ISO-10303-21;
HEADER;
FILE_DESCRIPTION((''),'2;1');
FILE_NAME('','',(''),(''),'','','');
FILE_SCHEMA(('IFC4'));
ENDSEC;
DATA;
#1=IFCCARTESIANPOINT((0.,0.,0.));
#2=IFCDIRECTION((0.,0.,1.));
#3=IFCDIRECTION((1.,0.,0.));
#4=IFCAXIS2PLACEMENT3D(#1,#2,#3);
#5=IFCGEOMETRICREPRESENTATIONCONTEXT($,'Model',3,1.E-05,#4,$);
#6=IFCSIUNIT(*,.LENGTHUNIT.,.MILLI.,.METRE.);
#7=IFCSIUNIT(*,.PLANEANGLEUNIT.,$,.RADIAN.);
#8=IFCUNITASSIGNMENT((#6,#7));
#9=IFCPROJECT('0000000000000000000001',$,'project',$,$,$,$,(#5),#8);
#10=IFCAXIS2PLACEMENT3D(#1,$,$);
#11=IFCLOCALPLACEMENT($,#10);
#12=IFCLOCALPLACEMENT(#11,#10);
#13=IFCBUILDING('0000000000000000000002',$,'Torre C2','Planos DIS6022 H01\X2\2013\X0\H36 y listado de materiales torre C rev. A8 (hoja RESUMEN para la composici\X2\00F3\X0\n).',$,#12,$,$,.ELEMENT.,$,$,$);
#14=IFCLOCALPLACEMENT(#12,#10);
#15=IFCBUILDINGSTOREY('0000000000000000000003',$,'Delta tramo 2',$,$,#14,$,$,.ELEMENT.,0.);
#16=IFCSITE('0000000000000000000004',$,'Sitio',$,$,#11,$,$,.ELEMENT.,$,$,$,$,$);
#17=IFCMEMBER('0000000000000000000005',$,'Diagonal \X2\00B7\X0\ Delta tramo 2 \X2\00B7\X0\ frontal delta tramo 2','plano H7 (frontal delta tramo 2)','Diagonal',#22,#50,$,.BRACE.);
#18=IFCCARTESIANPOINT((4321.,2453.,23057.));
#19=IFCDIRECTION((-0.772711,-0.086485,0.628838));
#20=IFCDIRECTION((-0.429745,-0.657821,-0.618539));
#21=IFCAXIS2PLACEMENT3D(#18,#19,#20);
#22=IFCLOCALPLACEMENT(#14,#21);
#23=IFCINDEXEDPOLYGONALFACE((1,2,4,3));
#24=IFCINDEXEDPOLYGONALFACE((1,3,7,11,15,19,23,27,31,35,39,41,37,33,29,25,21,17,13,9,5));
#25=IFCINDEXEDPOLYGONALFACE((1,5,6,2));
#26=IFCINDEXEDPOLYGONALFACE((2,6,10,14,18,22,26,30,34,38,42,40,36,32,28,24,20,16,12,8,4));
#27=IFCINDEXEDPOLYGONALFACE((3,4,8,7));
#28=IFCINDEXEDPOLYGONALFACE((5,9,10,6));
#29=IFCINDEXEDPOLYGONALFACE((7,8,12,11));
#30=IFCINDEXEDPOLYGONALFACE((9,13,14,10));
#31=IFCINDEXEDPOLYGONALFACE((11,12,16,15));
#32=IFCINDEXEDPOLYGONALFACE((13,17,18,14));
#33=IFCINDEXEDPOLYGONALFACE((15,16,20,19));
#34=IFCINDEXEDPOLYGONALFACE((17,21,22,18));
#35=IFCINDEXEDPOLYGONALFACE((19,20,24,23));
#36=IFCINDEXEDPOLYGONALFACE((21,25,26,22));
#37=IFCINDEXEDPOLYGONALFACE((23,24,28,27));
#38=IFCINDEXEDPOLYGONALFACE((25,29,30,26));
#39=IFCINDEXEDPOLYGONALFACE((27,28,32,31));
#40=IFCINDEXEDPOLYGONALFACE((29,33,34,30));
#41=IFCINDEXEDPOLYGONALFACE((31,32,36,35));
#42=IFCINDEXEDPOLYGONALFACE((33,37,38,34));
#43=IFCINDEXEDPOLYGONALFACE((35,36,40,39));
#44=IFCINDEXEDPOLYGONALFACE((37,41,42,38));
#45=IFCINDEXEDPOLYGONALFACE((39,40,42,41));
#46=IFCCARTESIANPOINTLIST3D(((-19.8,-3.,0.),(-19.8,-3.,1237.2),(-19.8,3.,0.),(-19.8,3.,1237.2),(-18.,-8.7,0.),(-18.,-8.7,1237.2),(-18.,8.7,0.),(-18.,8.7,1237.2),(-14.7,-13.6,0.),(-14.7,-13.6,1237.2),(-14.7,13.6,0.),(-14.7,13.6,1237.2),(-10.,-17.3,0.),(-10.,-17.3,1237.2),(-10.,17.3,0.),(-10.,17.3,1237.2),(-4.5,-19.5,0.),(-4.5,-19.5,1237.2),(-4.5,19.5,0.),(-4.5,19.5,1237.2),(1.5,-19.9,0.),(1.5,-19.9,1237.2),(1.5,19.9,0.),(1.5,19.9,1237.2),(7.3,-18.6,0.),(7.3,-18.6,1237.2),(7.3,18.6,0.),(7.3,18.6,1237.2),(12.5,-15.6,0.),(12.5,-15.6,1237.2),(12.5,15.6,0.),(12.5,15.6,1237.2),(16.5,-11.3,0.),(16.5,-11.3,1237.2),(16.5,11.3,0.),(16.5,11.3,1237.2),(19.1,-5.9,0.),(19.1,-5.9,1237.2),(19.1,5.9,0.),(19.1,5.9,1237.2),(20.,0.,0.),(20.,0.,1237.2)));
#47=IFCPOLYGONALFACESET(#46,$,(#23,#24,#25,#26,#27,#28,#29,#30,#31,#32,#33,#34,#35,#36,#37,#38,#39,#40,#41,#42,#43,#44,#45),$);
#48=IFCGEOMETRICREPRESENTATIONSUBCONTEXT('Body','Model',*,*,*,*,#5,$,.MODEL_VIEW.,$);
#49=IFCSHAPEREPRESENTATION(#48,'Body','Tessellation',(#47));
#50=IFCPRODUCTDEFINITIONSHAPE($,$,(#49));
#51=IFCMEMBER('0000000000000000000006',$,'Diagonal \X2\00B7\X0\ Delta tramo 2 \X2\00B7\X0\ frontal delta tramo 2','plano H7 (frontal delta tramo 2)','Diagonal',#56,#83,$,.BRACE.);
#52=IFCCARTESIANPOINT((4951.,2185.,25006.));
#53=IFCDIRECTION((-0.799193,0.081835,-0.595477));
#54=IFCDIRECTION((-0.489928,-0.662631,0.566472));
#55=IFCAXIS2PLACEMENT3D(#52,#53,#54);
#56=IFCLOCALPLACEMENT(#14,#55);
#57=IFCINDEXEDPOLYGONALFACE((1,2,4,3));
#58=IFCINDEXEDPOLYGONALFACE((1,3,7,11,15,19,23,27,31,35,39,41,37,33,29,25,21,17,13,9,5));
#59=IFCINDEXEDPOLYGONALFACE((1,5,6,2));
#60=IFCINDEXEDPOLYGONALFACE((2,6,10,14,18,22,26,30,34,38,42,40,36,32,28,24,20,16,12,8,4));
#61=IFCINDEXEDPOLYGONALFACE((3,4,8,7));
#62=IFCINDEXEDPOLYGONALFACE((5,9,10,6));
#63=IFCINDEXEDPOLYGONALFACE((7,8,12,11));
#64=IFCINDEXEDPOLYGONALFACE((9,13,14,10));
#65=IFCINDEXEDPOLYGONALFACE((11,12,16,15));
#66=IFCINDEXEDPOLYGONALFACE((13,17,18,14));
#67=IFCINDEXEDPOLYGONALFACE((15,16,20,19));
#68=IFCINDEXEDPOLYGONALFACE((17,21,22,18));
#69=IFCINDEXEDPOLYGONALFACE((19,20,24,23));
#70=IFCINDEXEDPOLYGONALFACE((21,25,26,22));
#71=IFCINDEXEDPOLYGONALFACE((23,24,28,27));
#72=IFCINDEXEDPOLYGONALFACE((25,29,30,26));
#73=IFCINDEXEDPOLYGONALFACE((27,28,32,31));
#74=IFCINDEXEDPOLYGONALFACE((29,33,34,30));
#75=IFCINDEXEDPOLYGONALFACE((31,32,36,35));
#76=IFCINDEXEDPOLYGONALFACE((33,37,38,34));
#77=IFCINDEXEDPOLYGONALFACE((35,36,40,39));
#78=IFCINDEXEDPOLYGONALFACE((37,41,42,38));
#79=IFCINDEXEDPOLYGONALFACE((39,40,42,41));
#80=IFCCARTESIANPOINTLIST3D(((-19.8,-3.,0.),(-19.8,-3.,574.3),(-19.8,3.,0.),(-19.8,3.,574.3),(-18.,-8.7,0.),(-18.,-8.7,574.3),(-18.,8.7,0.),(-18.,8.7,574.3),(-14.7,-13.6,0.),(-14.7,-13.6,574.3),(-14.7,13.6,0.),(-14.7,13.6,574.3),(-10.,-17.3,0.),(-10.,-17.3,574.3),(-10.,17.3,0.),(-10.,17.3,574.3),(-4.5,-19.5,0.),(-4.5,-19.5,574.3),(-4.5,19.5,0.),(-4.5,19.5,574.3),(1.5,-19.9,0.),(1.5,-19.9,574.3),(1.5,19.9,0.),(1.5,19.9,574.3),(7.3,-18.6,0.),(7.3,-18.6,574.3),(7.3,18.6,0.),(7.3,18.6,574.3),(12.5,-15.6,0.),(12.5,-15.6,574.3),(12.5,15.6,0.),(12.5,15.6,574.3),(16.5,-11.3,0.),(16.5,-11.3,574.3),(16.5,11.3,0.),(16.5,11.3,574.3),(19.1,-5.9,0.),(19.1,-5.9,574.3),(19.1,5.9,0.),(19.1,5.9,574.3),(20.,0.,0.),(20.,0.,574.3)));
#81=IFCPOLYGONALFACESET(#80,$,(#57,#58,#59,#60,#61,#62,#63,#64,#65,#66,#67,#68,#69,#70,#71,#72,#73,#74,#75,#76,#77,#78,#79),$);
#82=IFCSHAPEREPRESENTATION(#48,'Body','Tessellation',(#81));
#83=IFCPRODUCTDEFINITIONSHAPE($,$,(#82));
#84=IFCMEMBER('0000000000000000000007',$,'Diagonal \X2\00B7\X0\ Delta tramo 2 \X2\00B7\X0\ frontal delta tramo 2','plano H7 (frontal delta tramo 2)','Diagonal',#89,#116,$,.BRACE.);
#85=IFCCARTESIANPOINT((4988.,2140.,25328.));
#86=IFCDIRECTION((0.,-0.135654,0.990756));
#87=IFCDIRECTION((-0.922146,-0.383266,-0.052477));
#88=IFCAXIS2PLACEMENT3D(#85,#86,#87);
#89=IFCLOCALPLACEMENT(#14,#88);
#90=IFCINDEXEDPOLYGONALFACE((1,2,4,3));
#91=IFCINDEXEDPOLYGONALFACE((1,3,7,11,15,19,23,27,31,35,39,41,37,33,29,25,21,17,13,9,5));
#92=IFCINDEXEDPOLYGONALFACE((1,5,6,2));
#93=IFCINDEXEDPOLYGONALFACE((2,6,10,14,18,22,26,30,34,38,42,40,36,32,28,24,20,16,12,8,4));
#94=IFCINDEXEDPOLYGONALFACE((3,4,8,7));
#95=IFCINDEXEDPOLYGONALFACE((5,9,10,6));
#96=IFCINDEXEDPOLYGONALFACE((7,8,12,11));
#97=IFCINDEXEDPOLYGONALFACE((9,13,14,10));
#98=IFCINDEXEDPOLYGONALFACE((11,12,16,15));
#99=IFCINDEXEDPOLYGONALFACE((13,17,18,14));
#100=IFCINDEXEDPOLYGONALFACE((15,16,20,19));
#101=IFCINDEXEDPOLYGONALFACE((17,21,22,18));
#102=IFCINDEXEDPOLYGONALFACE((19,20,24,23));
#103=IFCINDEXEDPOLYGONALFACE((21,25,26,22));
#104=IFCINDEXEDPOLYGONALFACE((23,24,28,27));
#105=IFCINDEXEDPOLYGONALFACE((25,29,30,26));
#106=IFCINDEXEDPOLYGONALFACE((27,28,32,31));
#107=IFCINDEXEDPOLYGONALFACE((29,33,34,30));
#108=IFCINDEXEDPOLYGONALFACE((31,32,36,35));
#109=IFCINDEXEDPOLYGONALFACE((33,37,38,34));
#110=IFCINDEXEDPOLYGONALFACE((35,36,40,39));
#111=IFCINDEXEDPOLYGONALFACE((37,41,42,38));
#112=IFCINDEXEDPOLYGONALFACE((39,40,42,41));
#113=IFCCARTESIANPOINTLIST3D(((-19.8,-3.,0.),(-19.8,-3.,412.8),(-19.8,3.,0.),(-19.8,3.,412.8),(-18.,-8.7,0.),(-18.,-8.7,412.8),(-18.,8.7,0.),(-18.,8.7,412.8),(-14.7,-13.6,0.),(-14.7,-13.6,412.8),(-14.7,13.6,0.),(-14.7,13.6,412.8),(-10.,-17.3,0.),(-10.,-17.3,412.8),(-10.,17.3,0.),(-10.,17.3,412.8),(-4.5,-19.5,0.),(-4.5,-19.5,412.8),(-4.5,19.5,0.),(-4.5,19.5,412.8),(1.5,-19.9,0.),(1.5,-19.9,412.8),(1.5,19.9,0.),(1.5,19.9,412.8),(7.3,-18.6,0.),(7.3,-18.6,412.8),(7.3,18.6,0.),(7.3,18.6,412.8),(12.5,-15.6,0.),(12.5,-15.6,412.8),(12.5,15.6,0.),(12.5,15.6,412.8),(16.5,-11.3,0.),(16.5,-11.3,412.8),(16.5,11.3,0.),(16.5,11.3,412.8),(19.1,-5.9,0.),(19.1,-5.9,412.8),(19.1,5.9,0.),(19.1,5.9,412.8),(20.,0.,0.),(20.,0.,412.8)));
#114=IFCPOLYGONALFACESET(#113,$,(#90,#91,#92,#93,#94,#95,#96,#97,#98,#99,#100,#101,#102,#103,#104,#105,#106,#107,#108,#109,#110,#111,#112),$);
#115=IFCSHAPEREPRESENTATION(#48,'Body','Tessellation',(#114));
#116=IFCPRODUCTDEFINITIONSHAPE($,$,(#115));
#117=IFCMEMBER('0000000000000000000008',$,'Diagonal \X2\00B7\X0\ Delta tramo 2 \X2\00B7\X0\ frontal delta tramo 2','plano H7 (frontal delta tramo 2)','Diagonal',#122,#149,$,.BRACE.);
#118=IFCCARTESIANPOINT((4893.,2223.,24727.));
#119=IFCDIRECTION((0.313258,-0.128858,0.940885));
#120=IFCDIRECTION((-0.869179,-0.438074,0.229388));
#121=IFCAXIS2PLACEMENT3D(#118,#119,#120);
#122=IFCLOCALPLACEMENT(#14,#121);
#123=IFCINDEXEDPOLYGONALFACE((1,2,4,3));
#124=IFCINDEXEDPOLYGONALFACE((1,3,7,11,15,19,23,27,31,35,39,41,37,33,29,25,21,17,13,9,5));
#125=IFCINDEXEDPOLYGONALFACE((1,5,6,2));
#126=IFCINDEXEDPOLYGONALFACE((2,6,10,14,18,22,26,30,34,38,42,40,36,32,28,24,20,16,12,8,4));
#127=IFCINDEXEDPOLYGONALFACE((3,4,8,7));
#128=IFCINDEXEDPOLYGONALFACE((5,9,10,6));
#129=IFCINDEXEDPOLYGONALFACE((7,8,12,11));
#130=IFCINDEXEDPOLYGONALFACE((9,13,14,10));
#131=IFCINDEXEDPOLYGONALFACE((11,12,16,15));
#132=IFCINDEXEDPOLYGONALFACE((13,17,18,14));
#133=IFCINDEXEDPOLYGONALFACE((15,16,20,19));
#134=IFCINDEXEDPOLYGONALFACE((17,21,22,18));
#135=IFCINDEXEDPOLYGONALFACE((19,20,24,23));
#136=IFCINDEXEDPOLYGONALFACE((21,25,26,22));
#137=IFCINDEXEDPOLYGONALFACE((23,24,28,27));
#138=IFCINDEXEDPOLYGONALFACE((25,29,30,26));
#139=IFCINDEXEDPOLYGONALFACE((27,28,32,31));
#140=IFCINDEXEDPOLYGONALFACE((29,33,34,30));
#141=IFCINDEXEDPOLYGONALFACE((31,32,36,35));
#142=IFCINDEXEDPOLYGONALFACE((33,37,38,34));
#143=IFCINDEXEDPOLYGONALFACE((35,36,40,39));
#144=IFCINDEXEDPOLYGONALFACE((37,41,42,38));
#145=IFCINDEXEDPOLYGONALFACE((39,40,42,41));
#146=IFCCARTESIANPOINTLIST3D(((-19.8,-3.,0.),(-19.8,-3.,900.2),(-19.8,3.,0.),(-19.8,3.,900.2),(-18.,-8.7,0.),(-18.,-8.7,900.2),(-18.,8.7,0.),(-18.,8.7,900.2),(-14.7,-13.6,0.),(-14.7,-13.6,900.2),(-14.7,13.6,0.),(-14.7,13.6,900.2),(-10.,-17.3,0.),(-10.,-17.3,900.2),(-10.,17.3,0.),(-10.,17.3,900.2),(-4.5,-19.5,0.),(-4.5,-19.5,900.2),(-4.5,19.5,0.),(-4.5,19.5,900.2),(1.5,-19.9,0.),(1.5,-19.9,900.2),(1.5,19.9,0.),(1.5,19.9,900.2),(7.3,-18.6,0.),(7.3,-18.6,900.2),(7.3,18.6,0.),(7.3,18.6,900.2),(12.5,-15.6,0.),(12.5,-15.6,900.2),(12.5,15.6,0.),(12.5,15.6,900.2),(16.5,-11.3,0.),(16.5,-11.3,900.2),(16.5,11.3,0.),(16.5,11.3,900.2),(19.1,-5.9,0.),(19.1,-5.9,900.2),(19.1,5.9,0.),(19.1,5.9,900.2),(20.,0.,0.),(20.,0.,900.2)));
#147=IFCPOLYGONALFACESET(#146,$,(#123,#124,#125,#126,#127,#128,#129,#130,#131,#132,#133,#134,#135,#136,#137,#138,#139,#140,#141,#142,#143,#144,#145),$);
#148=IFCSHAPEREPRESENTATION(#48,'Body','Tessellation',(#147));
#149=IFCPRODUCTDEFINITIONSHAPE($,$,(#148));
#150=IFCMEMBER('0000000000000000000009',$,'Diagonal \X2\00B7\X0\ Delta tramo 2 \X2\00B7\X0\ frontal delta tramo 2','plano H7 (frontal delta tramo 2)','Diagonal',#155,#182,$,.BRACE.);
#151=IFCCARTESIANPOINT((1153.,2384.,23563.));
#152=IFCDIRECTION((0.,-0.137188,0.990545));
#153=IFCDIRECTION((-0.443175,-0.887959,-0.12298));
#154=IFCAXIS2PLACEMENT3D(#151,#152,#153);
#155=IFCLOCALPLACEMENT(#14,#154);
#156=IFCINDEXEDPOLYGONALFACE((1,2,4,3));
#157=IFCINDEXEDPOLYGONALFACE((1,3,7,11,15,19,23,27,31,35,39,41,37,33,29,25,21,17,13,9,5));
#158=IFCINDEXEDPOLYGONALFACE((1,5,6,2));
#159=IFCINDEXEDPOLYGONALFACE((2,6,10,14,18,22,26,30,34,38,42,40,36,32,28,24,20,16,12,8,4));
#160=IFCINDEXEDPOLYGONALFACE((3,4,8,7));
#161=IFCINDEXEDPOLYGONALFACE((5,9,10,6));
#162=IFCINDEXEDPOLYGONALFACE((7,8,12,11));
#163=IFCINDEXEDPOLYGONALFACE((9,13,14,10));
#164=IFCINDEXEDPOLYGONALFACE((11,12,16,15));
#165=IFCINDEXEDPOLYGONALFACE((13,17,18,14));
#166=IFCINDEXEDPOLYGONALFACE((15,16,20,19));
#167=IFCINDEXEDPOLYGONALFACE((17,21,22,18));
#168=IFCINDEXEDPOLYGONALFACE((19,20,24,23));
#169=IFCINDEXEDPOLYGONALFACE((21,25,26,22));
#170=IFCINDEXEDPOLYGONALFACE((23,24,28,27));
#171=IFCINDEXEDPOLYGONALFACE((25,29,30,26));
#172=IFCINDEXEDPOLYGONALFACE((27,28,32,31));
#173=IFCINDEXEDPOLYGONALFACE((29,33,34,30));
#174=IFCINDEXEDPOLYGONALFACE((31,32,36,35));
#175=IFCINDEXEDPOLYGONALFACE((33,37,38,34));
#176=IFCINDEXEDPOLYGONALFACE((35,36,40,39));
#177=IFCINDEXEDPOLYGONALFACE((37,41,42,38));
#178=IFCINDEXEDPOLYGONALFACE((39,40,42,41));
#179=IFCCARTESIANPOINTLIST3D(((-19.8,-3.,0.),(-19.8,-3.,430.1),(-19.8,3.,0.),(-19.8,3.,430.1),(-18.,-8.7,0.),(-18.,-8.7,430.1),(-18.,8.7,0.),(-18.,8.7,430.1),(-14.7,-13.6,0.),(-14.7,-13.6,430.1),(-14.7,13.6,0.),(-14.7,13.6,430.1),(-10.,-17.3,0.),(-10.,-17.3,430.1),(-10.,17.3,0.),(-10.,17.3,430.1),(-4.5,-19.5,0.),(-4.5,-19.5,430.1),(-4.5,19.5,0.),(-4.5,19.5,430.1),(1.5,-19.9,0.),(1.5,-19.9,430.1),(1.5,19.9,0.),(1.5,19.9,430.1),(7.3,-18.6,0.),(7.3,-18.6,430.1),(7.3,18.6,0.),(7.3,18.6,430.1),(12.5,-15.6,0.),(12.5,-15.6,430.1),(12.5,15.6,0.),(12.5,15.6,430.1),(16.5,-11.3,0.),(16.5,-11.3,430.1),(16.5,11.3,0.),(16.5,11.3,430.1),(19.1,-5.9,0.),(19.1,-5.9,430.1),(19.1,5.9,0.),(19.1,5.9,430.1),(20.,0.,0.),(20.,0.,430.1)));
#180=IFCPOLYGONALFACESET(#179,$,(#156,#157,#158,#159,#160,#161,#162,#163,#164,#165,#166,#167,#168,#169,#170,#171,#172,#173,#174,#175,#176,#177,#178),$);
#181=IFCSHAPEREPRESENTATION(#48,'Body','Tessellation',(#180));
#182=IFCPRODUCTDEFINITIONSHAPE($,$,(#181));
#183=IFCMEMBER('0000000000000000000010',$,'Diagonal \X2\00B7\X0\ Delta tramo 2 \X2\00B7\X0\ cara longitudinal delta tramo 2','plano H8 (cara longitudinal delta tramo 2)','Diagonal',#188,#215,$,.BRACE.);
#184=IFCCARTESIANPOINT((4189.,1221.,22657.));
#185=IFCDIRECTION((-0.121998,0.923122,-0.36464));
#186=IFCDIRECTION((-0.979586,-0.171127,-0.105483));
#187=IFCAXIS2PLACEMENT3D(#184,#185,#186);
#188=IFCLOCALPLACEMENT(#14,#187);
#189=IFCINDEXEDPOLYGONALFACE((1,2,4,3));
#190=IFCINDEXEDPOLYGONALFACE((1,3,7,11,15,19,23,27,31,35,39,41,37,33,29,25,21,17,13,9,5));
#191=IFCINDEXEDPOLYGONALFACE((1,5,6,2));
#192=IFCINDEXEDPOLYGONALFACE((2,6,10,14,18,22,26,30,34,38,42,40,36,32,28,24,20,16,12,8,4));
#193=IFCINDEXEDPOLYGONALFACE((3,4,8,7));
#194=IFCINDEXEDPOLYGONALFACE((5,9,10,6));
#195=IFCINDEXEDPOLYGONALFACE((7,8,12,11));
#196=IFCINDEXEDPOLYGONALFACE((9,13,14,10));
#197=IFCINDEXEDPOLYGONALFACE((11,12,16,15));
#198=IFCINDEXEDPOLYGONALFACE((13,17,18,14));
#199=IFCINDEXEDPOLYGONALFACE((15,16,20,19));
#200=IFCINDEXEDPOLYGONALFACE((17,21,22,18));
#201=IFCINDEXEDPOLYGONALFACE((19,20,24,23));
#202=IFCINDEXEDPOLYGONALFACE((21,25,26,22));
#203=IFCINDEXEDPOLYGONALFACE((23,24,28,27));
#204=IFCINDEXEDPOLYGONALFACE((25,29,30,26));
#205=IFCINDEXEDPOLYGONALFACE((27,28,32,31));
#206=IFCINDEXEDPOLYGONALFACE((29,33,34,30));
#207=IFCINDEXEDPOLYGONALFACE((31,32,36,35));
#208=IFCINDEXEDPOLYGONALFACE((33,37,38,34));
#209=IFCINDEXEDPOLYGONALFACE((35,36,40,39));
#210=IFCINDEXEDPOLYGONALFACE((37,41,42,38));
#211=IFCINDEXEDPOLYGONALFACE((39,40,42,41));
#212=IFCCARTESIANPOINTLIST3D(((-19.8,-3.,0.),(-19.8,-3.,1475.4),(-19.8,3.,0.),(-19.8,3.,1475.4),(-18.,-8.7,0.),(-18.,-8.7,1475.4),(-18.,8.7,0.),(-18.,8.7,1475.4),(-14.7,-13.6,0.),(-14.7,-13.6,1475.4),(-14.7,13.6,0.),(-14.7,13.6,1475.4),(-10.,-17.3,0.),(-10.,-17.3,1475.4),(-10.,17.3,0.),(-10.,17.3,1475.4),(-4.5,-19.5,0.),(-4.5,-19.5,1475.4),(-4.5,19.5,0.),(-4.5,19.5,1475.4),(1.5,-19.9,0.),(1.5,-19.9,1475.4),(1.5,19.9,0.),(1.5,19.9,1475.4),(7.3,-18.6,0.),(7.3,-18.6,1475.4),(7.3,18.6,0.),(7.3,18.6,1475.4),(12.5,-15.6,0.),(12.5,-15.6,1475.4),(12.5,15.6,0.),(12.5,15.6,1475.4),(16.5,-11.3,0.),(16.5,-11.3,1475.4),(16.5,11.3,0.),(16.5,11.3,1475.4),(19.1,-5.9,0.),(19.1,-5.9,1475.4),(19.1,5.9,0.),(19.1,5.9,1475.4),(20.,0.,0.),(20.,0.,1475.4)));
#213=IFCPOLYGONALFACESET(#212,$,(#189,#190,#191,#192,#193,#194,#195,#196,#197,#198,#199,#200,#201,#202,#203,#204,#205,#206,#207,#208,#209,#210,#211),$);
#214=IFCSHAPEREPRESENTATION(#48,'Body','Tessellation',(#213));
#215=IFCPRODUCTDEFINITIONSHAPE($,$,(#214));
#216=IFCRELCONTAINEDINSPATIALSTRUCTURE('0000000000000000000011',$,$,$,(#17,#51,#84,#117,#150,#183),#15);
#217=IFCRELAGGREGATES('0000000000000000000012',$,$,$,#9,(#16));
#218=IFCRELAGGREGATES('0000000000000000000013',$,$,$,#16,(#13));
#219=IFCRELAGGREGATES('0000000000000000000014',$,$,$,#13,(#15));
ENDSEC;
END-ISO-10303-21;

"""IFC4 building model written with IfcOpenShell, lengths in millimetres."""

from ifc_helpers import new_model, si_unit, frame, origin, origin_with_axes, place, context, subcontext, project, spatial, circle, extrude, element, save


model = new_model("IFC4")

# Units and contexts
model_context = context("Model", 3, precision=1e-05, world=origin_with_axes())
body_context = subcontext(model_context, "Body", "Model", "MODEL_VIEW")
ifc_project = project(units=[si_unit("LENGTHUNIT", "METRE", prefix="MILLI"), si_unit("PLANEANGLEUNIT", "RADIAN")], contexts=[model_context])

# Site, building, storey
site_placement = place(None, origin())
site = spatial("IfcSite", under=ifc_project, at=site_placement, Name="Sitio", CompositionType="ELEMENT")
building_placement = place(site_placement, origin())
building = spatial("IfcBuilding", under=site, at=building_placement, Name="Torre C2", Description="Planos DIS6022 H01–H36 y listado de materiales torre C rev. A8 (hoja RESUMEN para la composición).", CompositionType="ELEMENT")
storey_placement = place(building_placement, origin())
storey = spatial("IfcBuildingStorey", under=building, at=storey_placement, Name="Delta tramo 2", CompositionType="ELEMENT", Elevation=0.0)

# Members
member_1_placement = place(storey_placement, frame((4321.0, 2453.0, 23057.0), z_axis=(-0.772711, -0.086485, 0.628838), x_axis=(-0.429745, -0.657821, -0.618539)))
element("IfcMember", 1, at=member_1_placement, inside=storey, Name="Diagonal · Delta tramo 2 · frontal delta tramo 2", Description="plano H7 (frontal delta tramo 2)", ObjectType="Diagonal", PredefinedType="BRACE", context=body_context, shape_type="SweptSolid", body=[
    extrude(circle(Radius=20.0), None, (0.0, 0.0, 1.0), 1237.2),
])
member_2_placement = place(storey_placement, frame((4951.0, 2185.0, 25006.0), z_axis=(-0.799193, 0.081835, -0.595477), x_axis=(-0.489928, -0.662631, 0.566472)))
element("IfcMember", 2, at=member_2_placement, inside=storey, Name="Diagonal · Delta tramo 2 · frontal delta tramo 2", Description="plano H7 (frontal delta tramo 2)", ObjectType="Diagonal", PredefinedType="BRACE", context=body_context, shape_type="SweptSolid", body=[
    extrude(circle(Radius=20.0), None, (0.0, 0.0, 1.0), 574.3),
])
member_3_placement = place(storey_placement, frame((4988.0, 2140.0, 25328.0), z_axis=(0.0, -0.135654, 0.990756), x_axis=(-0.922146, -0.383266, -0.052477)))
element("IfcMember", 3, at=member_3_placement, inside=storey, Name="Diagonal · Delta tramo 2 · frontal delta tramo 2", Description="plano H7 (frontal delta tramo 2)", ObjectType="Diagonal", PredefinedType="BRACE", context=body_context, shape_type="SweptSolid", body=[
    extrude(circle(Radius=20.0), None, (0.0, 0.0, 1.0), 412.8),
])
member_4_placement = place(storey_placement, frame((4893.0, 2223.0, 24727.0), z_axis=(0.313258, -0.128858, 0.940885), x_axis=(-0.869179, -0.438074, 0.229388)))
element("IfcMember", 4, at=member_4_placement, inside=storey, Name="Diagonal · Delta tramo 2 · frontal delta tramo 2", Description="plano H7 (frontal delta tramo 2)", ObjectType="Diagonal", PredefinedType="BRACE", context=body_context, shape_type="SweptSolid", body=[
    extrude(circle(Radius=20.0), None, (0.0, 0.0, 1.0), 900.2),
])
for number, where, z_axis, x_axis, name in (
    (5, (1153.0, 2384.0, 23563.0), (0.0, -0.137188, 0.990545), (-0.443175, -0.887959, -0.12298), "Diagonal · Delta tramo 2 · frontal delta tramo 2"),
):
    element("IfcMember", number, at=place(storey_placement, frame(where, z_axis=z_axis, x_axis=x_axis)), inside=storey, Name=name, Description="plano H7 (frontal delta tramo 2)", ObjectType="Diagonal", PredefinedType="BRACE", context=body_context, shape_type="SweptSolid", body=[
        extrude(circle(Radius=20.0), None, (0.0, 0.0, 1.0), 430.1),
    ])
member_5_placement = place(storey_placement, frame((4189.0, 1221.0, 22657.0), z_axis=(-0.121998, 0.923122, -0.36464), x_axis=(-0.979586, -0.171127, -0.105483)))
element("IfcMember", 6, at=member_5_placement, inside=storey, Name="Diagonal · Delta tramo 2 · cara longitudinal delta tramo 2", Description="plano H8 (cara longitudinal delta tramo 2)", ObjectType="Diagonal", PredefinedType="BRACE", context=body_context, shape_type="SweptSolid", body=[
    extrude(circle(Radius=20.0), None, (0.0, 0.0, 1.0), 1475.4),
])

save(model, "model.ifc")
